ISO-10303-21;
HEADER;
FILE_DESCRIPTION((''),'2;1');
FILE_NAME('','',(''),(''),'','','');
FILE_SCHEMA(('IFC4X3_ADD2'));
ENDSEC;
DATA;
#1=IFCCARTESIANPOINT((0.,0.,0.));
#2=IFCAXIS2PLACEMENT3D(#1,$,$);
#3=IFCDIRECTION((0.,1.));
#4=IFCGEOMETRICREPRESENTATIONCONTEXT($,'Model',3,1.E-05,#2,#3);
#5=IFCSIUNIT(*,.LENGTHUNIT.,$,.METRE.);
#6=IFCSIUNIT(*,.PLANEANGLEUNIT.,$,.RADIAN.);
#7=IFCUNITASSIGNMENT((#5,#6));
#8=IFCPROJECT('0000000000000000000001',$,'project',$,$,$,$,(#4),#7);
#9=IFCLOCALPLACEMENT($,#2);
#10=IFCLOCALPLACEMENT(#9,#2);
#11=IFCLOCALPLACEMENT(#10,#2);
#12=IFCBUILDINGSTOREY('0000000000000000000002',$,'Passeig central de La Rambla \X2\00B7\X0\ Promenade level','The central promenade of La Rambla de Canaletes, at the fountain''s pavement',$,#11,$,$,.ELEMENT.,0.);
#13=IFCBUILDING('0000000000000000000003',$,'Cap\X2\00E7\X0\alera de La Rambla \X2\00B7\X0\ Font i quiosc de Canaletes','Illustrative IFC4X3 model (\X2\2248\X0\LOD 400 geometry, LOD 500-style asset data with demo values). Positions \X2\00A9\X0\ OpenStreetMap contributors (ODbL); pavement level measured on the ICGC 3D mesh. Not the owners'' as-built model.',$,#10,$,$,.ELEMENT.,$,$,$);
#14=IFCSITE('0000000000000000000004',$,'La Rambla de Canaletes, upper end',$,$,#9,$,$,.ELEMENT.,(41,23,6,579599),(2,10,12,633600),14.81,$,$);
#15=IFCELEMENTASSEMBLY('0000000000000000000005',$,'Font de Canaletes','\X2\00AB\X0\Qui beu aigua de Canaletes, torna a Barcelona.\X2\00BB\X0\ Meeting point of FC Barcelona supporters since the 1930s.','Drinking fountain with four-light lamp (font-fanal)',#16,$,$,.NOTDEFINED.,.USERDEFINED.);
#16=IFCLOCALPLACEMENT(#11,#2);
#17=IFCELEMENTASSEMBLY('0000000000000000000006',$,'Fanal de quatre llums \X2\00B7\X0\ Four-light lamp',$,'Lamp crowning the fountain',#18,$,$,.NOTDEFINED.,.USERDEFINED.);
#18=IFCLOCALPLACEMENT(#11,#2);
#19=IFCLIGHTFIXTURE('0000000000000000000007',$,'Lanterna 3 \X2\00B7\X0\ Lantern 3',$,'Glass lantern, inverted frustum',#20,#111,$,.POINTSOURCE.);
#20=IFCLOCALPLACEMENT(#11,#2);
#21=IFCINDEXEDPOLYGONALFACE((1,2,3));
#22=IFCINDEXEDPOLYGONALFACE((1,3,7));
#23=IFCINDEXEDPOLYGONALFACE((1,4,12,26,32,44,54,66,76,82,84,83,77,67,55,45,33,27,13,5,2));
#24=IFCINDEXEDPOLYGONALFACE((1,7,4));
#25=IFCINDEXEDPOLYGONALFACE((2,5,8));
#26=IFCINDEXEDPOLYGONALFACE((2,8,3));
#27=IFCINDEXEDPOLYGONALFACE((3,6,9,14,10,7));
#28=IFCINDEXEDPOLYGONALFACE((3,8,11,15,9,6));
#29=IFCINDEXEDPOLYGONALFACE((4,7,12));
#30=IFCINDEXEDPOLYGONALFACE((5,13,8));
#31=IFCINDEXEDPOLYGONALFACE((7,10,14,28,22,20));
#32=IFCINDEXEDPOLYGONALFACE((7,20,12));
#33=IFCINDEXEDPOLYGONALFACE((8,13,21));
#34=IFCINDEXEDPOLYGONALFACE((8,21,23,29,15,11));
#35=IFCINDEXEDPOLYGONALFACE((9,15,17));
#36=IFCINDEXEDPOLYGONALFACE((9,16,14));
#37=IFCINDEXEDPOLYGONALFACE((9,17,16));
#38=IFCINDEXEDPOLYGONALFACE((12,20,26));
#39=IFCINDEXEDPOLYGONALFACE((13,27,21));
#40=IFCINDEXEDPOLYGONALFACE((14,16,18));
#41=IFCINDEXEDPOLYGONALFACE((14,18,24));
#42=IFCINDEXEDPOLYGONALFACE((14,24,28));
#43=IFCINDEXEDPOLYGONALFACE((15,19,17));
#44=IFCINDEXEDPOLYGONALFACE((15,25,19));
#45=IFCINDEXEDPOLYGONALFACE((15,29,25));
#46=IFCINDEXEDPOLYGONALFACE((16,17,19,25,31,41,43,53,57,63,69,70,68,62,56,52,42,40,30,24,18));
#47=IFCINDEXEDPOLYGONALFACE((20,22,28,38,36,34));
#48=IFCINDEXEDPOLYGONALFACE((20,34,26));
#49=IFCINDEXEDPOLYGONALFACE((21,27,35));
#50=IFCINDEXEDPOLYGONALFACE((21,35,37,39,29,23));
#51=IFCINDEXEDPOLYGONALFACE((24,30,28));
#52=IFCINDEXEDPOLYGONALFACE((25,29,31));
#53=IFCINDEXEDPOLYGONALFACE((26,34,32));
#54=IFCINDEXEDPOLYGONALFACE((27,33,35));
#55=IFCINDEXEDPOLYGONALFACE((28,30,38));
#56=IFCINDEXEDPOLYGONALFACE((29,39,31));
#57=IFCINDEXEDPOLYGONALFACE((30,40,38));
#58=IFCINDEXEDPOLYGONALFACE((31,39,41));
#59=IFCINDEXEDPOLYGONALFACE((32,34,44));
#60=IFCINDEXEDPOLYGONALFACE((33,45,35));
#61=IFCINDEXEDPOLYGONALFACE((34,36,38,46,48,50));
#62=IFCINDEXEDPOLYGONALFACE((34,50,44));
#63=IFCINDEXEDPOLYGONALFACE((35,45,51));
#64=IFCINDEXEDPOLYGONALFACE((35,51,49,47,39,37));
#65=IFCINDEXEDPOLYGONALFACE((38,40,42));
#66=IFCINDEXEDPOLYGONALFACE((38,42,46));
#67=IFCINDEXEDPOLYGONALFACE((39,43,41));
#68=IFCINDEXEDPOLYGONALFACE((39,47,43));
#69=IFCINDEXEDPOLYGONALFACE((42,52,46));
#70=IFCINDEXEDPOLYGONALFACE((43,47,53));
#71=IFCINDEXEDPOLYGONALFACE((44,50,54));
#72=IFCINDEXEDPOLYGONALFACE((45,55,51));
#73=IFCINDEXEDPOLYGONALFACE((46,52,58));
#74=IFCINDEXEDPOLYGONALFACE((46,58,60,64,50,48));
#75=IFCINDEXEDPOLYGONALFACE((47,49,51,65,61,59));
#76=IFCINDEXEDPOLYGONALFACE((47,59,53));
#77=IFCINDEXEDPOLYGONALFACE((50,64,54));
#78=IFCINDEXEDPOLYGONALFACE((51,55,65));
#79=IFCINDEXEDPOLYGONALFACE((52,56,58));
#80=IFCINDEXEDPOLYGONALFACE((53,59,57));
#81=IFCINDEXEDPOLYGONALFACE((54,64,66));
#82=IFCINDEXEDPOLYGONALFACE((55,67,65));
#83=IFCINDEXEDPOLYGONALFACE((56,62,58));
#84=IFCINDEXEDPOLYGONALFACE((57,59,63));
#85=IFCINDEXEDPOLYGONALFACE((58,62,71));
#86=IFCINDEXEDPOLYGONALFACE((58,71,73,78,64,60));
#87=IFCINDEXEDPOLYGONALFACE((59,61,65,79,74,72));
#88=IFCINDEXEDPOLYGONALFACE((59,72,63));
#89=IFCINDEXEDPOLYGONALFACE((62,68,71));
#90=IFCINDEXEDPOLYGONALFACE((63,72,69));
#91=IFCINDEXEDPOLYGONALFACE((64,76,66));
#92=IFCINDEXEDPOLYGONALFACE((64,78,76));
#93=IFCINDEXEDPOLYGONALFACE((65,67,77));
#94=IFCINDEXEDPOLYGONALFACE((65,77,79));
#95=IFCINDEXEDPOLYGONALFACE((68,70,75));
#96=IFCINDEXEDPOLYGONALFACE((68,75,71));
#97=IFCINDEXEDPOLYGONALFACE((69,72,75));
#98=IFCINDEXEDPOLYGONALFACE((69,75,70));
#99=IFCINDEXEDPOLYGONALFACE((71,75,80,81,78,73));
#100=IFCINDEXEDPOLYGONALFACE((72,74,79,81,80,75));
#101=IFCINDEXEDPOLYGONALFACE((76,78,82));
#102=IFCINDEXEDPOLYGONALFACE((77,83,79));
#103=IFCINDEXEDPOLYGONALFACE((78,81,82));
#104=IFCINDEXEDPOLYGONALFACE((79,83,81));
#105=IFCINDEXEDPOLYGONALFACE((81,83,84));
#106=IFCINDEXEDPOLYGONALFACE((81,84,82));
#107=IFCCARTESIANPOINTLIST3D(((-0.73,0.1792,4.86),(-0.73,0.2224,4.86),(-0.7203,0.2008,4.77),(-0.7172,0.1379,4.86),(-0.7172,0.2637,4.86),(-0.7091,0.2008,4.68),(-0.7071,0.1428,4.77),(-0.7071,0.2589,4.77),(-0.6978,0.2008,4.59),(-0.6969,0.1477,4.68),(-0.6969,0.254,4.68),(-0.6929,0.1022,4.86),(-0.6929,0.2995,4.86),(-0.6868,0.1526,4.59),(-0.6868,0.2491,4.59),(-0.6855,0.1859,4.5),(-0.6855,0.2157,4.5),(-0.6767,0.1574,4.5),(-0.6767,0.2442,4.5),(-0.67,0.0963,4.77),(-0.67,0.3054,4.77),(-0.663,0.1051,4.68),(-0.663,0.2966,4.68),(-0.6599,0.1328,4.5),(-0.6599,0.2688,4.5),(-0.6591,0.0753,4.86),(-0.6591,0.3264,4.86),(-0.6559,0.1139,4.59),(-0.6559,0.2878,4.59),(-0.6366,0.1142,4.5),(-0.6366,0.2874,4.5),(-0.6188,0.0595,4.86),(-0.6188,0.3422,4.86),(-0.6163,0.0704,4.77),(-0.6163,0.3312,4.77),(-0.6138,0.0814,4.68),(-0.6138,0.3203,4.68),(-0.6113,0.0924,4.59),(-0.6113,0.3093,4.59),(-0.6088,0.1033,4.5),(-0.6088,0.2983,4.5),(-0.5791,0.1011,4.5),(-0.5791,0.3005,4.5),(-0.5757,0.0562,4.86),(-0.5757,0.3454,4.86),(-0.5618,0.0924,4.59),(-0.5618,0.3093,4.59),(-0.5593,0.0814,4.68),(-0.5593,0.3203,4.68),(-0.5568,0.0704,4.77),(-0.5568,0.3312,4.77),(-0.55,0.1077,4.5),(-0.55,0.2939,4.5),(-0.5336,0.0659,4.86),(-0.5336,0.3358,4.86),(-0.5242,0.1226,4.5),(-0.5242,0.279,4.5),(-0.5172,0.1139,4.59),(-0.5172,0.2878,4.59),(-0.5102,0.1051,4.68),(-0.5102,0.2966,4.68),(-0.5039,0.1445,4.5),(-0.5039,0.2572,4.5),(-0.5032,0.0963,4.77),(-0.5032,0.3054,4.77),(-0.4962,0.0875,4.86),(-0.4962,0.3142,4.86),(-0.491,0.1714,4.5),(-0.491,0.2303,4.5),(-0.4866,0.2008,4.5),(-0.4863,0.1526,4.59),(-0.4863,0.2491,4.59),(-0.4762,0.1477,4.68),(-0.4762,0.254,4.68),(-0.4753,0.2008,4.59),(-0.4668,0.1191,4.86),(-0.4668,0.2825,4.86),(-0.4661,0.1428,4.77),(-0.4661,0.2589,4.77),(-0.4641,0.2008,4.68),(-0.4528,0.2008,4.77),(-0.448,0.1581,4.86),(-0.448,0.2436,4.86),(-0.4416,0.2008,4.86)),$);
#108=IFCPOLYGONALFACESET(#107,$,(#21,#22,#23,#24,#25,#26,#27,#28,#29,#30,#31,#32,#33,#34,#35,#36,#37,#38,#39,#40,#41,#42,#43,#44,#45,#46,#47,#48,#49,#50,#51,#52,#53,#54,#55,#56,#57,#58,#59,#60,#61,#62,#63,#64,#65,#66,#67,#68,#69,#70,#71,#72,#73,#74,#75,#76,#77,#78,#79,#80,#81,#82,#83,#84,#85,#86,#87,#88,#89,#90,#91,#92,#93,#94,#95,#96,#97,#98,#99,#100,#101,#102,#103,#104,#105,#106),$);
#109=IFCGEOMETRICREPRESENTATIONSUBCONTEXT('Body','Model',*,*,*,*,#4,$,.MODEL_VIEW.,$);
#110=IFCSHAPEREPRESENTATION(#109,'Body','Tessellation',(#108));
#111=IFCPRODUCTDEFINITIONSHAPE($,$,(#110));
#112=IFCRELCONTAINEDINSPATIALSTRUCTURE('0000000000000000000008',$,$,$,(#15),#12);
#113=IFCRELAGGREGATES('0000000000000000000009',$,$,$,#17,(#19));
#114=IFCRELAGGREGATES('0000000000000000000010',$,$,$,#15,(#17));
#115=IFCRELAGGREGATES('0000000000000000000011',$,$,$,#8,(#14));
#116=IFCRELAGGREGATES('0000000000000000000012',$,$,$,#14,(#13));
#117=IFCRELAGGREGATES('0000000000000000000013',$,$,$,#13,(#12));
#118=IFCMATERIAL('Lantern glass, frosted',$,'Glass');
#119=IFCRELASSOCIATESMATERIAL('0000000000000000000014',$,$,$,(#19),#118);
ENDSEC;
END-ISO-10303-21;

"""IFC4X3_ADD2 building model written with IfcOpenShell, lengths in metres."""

from ifc_helpers import new_model, entity, si_unit, direction, origin, place, context, subcontext, project, spatial, material, element, aggregate, save


model = new_model("IFC4X3_ADD2")

# Units and contexts
model_context = context("Model", 3, precision=1e-05, world=origin(), true_north=direction((0.0, 1.0)))
body_context = subcontext(model_context, "Body", "Model", "MODEL_VIEW")
ifc_project = project(units=[si_unit("LENGTHUNIT", "METRE"), si_unit("PLANEANGLEUNIT", "RADIAN")], contexts=[model_context])

# Site, building, storey
site_placement = place(None, origin())
site = spatial("IfcSite", under=ifc_project, at=site_placement, Name="La Rambla de Canaletes, upper end", CompositionType="ELEMENT", RefLatitude=(41, 23, 6, 579599), RefLongitude=(2, 10, 12, 633600), RefElevation=14.81)
building_placement = place(site_placement, origin())
building = spatial("IfcBuilding", under=site, at=building_placement, Name="Capçalera de La Rambla · Font i quiosc de Canaletes", Description="Illustrative IFC4X3 model (≈LOD 400 geometry, LOD 500-style asset data with demo values). Positions © OpenStreetMap contributors (ODbL); pavement level measured on the ICGC 3D mesh. Not the owners' as-built model.", CompositionType="ELEMENT")
storey_placement = place(building_placement, origin())
storey = spatial("IfcBuildingStorey", under=building, at=storey_placement, Name="Passeig central de La Rambla · Promenade level", Description="The central promenade of La Rambla de Canaletes, at the fountain's pavement", CompositionType="ELEMENT", Elevation=0.0)

# Element assemblies, light fixture
assembly_1_placement = place(building_placement, origin())
assembly_1 = element("IfcElementAssembly", 1, at=assembly_1_placement, inside=storey, Name="Font de Canaletes", Description="«Qui beu aigua de Canaletes, torna a Barcelona.» Meeting point of FC Barcelona supporters since the 1930s.", ObjectType="Drinking fountain with four-light lamp (font-fanal)", AssemblyPlace="NOTDEFINED", PredefinedType="USERDEFINED")
assembly_2_placement = place(building_placement, origin())
assembly_2 = element("IfcElementAssembly", 2, at=assembly_2_placement, Name="Fanal de quatre llums · Four-light lamp", ObjectType="Lamp crowning the fountain", AssemblyPlace="NOTDEFINED", PredefinedType="USERDEFINED")
ifc_material_1 = material(Name="Lantern glass, frosted", Category="Glass")
light_fixture_1_placement = place(building_placement, origin())
light_fixture_1 = element("IfcLightFixture", 3, at=light_fixture_1_placement, material=ifc_material_1, Name="Lanterna 3 · Lantern 3", ObjectType="Glass lantern, inverted frustum", PredefinedType="POINTSOURCE", context=body_context, shape_type="SweptSolid", body=[
    entity("IfcRevolvedAreaSolid", entity("IfcArbitraryClosedProfileDef", "AREA", None, entity("IfcPolyline", [entity("IfcCartesianPoint", [0.0, 0.0]), entity("IfcCartesianPoint", [0.1, 0.0]), entity("IfcCartesianPoint", [0.145, 0.36]), entity("IfcCartesianPoint", [0.0, 0.36]), entity("IfcCartesianPoint", [0.0, 0.0])])), entity("IfcAxis2Placement3D", entity("IfcCartesianPoint", [-0.5866, 0.2008, 4.5]), entity("IfcDirection", [0.0, -1.0, 0.0]), entity("IfcDirection", [1.0, 0.0, 0.0])), entity("IfcAxis1Placement", entity("IfcCartesianPoint", [0.0, 0.0, 0.0]), entity("IfcDirection", [0.0, 1.0, 0.0])), 6.283185),
])
aggregate(assembly_2, [light_fixture_1])
aggregate(assembly_1, [assembly_2])

save(model, "model.ifc")
